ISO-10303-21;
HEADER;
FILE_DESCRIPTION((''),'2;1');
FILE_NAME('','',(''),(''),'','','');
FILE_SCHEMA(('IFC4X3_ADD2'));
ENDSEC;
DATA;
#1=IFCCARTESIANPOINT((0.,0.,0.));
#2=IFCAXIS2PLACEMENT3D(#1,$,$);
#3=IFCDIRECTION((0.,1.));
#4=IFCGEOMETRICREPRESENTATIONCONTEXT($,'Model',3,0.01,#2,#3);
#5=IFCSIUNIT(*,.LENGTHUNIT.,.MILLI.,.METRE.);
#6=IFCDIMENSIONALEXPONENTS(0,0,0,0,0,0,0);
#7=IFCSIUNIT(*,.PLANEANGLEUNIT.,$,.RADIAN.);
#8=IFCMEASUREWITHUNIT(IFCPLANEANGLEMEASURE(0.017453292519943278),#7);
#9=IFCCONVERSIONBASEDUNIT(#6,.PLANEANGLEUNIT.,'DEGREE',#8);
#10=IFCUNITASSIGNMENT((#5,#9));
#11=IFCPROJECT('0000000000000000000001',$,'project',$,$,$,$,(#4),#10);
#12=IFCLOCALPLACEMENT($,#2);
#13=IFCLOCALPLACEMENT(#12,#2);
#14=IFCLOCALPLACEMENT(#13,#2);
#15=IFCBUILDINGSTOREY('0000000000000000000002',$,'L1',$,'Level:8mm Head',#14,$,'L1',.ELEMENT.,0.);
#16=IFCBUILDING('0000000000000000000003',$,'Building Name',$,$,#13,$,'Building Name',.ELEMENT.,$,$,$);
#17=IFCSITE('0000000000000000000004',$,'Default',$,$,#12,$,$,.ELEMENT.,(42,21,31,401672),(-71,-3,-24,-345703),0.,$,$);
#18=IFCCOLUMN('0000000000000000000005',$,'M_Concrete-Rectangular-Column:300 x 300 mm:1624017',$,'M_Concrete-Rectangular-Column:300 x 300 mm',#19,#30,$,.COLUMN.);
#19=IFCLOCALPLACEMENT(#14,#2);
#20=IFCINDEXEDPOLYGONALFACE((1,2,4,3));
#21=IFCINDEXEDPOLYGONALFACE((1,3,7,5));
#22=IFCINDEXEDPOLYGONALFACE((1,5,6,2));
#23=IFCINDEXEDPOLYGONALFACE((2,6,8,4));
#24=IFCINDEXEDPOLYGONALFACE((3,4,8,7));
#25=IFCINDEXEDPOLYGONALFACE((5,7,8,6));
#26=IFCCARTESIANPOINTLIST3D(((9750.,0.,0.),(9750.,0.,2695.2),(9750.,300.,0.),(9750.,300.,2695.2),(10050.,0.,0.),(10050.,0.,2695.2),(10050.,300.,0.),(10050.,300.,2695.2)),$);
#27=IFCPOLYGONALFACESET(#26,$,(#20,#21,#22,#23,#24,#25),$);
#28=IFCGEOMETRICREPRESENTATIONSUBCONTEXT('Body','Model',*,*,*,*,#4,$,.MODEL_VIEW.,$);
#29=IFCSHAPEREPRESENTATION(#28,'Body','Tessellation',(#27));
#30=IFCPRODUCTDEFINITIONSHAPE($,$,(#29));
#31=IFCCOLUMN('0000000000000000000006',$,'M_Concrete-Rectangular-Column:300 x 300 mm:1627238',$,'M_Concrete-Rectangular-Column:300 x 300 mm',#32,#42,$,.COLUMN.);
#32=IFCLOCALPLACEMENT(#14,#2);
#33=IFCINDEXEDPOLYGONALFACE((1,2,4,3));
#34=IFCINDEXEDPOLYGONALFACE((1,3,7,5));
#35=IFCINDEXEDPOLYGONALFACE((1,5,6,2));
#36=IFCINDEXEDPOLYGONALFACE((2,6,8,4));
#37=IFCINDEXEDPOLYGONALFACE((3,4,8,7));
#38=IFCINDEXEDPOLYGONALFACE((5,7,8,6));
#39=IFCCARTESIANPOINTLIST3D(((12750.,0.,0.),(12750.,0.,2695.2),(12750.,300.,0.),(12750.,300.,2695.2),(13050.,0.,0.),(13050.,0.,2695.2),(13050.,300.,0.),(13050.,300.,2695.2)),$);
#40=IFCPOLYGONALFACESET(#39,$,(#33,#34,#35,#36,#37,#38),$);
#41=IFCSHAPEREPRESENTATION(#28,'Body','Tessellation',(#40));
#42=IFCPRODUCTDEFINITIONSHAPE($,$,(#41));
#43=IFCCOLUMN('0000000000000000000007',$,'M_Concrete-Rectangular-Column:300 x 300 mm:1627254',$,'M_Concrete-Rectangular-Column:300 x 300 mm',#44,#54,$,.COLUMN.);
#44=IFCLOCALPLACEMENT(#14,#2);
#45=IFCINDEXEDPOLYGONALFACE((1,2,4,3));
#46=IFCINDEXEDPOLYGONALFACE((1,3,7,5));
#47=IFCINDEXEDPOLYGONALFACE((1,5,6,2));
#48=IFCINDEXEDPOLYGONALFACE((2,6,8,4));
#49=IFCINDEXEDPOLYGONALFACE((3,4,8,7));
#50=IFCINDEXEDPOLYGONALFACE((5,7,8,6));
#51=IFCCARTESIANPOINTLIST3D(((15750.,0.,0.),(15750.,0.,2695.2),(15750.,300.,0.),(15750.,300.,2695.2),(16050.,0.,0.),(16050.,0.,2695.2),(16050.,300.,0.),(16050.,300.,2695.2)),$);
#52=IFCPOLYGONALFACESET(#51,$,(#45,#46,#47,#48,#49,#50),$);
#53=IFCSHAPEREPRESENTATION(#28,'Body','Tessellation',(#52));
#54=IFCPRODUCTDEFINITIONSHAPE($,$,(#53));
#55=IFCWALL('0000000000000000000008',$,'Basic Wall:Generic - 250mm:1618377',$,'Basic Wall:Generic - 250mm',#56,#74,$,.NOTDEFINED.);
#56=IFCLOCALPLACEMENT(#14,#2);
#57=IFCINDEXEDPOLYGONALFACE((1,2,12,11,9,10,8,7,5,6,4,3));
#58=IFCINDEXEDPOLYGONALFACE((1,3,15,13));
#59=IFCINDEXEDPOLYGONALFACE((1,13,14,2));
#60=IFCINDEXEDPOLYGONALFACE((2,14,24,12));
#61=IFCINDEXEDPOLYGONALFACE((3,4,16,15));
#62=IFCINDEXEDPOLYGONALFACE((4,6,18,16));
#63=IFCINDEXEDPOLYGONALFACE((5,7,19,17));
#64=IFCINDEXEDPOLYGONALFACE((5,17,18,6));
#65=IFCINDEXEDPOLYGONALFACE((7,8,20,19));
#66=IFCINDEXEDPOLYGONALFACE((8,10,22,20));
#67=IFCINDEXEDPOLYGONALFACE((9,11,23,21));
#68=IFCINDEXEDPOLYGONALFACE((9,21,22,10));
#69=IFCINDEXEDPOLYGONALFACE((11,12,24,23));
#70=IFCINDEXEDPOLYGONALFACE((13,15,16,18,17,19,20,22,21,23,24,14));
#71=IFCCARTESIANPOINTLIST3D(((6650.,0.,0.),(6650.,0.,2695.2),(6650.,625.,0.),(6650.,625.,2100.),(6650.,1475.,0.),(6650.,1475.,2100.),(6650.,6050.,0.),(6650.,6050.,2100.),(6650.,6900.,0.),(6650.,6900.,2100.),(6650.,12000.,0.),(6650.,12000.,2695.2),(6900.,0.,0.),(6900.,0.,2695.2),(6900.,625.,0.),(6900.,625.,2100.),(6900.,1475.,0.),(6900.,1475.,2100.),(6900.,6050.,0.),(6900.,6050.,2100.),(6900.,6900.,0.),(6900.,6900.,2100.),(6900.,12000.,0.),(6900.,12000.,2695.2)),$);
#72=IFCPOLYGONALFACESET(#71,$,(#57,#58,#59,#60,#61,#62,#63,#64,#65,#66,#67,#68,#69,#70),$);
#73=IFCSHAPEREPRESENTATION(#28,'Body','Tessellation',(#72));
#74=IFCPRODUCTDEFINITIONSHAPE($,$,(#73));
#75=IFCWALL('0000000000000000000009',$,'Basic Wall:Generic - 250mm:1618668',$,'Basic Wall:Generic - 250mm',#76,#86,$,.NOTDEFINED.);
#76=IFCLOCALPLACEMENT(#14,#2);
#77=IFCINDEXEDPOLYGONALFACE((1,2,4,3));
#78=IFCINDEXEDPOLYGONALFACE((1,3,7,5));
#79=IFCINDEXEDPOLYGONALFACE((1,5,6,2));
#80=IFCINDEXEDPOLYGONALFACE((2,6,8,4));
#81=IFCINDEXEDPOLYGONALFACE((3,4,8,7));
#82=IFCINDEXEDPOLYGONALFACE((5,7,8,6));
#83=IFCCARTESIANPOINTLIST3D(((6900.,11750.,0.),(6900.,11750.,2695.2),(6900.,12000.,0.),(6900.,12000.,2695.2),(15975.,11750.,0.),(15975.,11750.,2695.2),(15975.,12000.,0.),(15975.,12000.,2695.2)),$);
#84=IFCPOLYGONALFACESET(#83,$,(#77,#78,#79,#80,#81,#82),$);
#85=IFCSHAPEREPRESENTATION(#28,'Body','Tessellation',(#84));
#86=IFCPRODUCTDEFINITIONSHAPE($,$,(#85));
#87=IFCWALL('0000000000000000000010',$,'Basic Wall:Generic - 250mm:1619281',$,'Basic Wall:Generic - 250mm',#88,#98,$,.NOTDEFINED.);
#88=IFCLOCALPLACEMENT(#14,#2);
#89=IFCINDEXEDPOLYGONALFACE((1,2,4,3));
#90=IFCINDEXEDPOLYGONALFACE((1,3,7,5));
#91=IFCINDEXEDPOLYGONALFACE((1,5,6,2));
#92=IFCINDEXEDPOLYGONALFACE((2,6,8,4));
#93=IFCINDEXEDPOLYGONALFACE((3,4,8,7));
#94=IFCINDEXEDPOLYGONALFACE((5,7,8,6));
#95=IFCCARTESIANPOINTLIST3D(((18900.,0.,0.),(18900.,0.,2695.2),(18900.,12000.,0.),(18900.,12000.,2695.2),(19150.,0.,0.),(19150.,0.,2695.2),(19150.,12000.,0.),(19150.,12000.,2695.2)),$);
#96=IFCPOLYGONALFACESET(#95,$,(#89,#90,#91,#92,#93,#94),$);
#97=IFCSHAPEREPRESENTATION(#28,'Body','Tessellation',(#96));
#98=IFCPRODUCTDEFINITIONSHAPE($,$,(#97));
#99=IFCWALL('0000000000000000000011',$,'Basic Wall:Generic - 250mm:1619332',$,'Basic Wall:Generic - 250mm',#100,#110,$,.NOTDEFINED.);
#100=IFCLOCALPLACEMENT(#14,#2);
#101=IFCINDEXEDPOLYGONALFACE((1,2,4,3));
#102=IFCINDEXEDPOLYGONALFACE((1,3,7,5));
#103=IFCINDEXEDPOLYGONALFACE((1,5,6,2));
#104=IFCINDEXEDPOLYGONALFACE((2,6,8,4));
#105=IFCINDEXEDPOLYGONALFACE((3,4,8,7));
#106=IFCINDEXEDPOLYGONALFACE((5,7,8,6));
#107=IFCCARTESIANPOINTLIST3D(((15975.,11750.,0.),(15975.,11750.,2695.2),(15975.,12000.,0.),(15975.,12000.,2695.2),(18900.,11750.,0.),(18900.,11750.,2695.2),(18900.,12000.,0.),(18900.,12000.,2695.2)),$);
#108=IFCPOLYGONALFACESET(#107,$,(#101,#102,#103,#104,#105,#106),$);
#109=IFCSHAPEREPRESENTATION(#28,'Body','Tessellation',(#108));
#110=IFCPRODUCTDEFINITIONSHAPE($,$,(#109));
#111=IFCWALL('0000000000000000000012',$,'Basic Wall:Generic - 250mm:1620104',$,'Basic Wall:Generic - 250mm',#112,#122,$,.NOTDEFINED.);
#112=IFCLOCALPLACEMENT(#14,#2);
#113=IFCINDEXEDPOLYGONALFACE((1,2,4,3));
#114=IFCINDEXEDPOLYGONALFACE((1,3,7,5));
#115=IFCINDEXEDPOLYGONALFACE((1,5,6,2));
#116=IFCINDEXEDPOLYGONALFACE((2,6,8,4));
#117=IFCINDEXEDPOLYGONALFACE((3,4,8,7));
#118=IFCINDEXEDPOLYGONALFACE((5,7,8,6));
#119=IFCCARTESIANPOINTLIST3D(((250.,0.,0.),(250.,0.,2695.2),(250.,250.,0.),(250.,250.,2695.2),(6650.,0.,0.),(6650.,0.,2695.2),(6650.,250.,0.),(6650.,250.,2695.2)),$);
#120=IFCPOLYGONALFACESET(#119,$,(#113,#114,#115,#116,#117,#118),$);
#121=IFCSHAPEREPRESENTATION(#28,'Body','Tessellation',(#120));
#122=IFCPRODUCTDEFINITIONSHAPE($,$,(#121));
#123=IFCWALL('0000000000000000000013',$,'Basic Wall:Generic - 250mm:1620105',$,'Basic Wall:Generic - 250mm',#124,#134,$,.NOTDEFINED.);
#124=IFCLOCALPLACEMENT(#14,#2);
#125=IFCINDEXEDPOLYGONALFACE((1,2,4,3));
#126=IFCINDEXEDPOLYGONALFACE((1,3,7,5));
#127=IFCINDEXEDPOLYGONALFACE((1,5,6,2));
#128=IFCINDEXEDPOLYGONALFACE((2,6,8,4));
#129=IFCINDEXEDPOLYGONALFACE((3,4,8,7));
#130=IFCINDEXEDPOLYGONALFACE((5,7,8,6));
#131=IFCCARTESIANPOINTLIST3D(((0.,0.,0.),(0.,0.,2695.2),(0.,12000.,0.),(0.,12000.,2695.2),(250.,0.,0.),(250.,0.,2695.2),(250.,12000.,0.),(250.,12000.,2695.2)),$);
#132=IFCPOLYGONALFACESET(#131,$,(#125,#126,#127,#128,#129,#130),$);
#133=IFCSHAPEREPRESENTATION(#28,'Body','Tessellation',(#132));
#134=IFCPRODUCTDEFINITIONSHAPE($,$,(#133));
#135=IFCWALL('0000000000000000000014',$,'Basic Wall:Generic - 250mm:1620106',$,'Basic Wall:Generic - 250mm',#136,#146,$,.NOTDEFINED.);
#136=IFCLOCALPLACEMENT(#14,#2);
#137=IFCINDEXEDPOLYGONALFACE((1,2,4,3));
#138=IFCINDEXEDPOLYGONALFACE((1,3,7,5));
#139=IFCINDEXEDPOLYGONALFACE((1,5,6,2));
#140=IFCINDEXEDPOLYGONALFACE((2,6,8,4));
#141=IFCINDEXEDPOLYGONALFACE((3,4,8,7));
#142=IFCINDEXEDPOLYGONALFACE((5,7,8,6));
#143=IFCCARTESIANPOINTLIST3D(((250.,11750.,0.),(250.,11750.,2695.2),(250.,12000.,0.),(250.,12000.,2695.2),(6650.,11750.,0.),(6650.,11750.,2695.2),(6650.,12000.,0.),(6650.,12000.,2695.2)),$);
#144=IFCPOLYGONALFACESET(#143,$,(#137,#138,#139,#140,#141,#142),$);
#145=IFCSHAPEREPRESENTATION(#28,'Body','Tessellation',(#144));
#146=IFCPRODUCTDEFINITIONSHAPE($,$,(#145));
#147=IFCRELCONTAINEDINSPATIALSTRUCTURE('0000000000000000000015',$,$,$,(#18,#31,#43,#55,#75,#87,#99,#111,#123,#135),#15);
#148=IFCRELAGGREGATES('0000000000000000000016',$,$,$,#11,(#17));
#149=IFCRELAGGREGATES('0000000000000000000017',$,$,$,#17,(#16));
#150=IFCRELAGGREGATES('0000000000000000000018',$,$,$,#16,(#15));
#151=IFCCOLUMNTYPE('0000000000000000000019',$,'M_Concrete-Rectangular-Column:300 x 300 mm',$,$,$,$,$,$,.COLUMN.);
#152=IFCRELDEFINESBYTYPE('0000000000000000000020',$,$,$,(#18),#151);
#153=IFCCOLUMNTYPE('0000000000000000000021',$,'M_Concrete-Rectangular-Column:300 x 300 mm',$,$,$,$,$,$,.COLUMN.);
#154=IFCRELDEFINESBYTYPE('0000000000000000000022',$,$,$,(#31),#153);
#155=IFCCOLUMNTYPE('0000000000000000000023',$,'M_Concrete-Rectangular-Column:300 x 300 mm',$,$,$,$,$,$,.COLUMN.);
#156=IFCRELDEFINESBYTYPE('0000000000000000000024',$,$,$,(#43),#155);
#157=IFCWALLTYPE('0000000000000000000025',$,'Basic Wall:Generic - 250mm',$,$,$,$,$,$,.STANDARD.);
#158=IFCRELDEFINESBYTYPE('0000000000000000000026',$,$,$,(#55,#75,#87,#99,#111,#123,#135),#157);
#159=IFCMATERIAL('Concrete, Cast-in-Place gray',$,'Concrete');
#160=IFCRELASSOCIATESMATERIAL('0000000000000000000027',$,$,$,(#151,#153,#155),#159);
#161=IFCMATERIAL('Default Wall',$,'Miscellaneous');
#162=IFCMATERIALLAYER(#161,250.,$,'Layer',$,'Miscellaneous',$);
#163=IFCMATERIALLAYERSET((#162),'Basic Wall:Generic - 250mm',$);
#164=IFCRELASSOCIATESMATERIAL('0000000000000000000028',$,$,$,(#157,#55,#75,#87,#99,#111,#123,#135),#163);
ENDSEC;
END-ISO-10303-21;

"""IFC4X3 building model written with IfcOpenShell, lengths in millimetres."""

from ifc_helpers import new_model, entity, si_unit, converted_unit, direction, frame, frame_2d, origin, place, context, subcontext, project, spatial, polyline, rectangle, extrude, clip, bounded_halfspace, source, transform, mapped, material, layer, layer_set, material_profile, profile_set, type_object, type_shapes, element, save


model = new_model("IFC4X3")

# Units and contexts
model_context = context("Model", 3, precision=0.01, world=origin(), true_north=direction((0.0, 1.0)))
body_context = subcontext(model_context, "Body", "Model", "MODEL_VIEW")
ifc_project = project(units=[si_unit("LENGTHUNIT", "METRE", prefix="MILLI"), converted_unit("PLANEANGLEUNIT", "DEGREE", entity("IfcPlaneAngleMeasure", 0.017453292519943278), si_unit("PLANEANGLEUNIT", "RADIAN"), dimensions=[0, 0, 0, 0, 0, 0, 0])], contexts=[model_context])

# Site, building, storey
site_placement = place(None, origin())
site = spatial("IfcSite", under=ifc_project, at=site_placement, Name="Default", CompositionType="ELEMENT", RefLatitude=(42, 21, 31, 401672), RefLongitude=(-71, -3, -24, -345703), RefElevation=0.0)
building_placement = place(site_placement, origin())
building = spatial("IfcBuilding", under=site, at=building_placement, Name="Building Name", LongName="Building Name", CompositionType="ELEMENT")
storey_placement = place(building_placement, origin())
storey = spatial("IfcBuildingStorey", under=building, at=storey_placement, Name="L1", ObjectType="Level:8mm Head", LongName="L1", CompositionType="ELEMENT", Elevation=0.0)

# Columns
ifc_material_1 = material(Name="Concrete, Cast-in-Place gray", Category="Concrete")
ifc_material_profile = material_profile(ifc_material_1, rectangle(XDim=300.0, YDim=300.0, at=frame_2d((0.0, 0.0), x_axis=(1.0, 0.0))), Name="300 x 300 mm")
ifc_profile_set = profile_set([ifc_material_profile], Name="300 x 300 mm")
column_type_1 = type_object("IfcColumnType", Name="M_Concrete-Rectangular-Column:300 x 300 mm", PredefinedType="COLUMN", material=ifc_profile_set)
shared_shape_1 = source(origin(), body_context, "Body", "SweptSolid", [
    extrude(rectangle(XDim=300.0, YDim=300.0, at=frame_2d((0.0, 0.0), x_axis=(1.0, 0.0))), frame((9900.0, 150.0, 0.0), z_axis=(0.0, 0.0, 1.0), x_axis=(-1.0, 0.0, 0.0)), (0.0, 0.0, 1.0), 2695.2),
])
type_shapes(column_type_1, [shared_shape_1])
column_1_placement = place(storey_placement, origin())
element("IfcColumn", 1, at=column_1_placement, inside=storey, type_object=column_type_1, Name="M_Concrete-Rectangular-Column:300 x 300 mm:1624017", ObjectType="M_Concrete-Rectangular-Column:300 x 300 mm", PredefinedType="COLUMN", context=body_context, shape_type="MappedRepresentation", body=[
    mapped(shared_shape_1, transform((0.0, 0.0, 0.0), scale=1.0)),
])
column_type_2 = type_object("IfcColumnType", Name="M_Concrete-Rectangular-Column:300 x 300 mm", PredefinedType="COLUMN", material=ifc_profile_set)
shared_shape_2 = source(origin(), body_context, "Body", "SweptSolid", [
    extrude(rectangle(XDim=300.0, YDim=300.0, at=frame_2d((0.0, 0.0), x_axis=(1.0, 0.0))), frame((12900.0, 150.0, 0.0), z_axis=(0.0, 0.0, 1.0), x_axis=(-1.0, 0.0, 0.0)), (0.0, 0.0, 1.0), 2695.2),
])
type_shapes(column_type_2, [shared_shape_2])
column_2_placement = place(storey_placement, origin())
element("IfcColumn", 2, at=column_2_placement, inside=storey, type_object=column_type_2, Name="M_Concrete-Rectangular-Column:300 x 300 mm:1627238", ObjectType="M_Concrete-Rectangular-Column:300 x 300 mm", PredefinedType="COLUMN", context=body_context, shape_type="MappedRepresentation", body=[
    mapped(shared_shape_2, transform((0.0, 0.0, 0.0), scale=1.0)),
])
column_type_3 = type_object("IfcColumnType", Name="M_Concrete-Rectangular-Column:300 x 300 mm", PredefinedType="COLUMN", material=ifc_profile_set)
shared_shape_3 = source(origin(), body_context, "Body", "SweptSolid", [
    extrude(rectangle(XDim=300.0, YDim=300.0, at=frame_2d((0.0, 0.0), x_axis=(1.0, 0.0))), frame((15900.0, 150.0, 0.0), z_axis=(0.0, 0.0, 1.0), x_axis=(-1.0, 0.0, 0.0)), (0.0, 0.0, 1.0), 2695.2),
])
type_shapes(column_type_3, [shared_shape_3])
column_3_placement = place(storey_placement, origin())
element("IfcColumn", 3, at=column_3_placement, inside=storey, type_object=column_type_3, Name="M_Concrete-Rectangular-Column:300 x 300 mm:1627254", ObjectType="M_Concrete-Rectangular-Column:300 x 300 mm", PredefinedType="COLUMN", context=body_context, shape_type="MappedRepresentation", body=[
    mapped(shared_shape_3, transform((0.0, 0.0, 0.0), scale=1.0)),
])

# Wall, openings
ifc_material_2 = material(Name="Default Wall", Category="Miscellaneous")
ifc_layer = layer(ifc_material_2, 250.0, Name="Layer", Category="Miscellaneous")
ifc_layer_set = layer_set([ifc_layer], Name="Basic Wall:Generic - 250mm")
wall_type = type_object("IfcWallType", Name="Basic Wall:Generic - 250mm", PredefinedType="STANDARD", material=ifc_layer_set)
wall_1_placement = place(storey_placement, frame((6775.0, 12000.0, 0.0), z_axis=(0.0, 0.0, 1.0), x_axis=(0.0, -1.0, 0.0)))
wall_1 = element("IfcWall", 4, at=wall_1_placement, inside=storey, type_object=wall_type, material=ifc_layer_set, Name="Basic Wall:Generic - 250mm:1618377", ObjectType="Basic Wall:Generic - 250mm", PredefinedType="NOTDEFINED", context=body_context, shape_type="Clipping", body=[
    clip(extrude(rectangle(XDim=12000.0, YDim=250.0, at=frame_2d((6000.0, 0.0), x_axis=(1.0, 0.0))), origin(), (0.0, 0.0, 1.0), 2695.2), bounded_halfspace(frame((0.0, -125.0, 2695.2), z_axis=(0.0, 0.0, -1.0), x_axis=(0.0, -1.0, 0.0)), True, frame((0.0, -125.0, 2695.2)), polyline([(0.0, 0.0), (250.0, 0.0), (11750.0, 0.0), (12000.0, 0.0), (12000.0, 250.0), (250.0, 250.0), (0.0, 250.0), (0.0, 0.0)]))),
])
opening_1_placement = place(wall_1_placement, frame((10525.0, -125.0, 0.0)))
element("IfcOpeningElement", 5, at=opening_1_placement, cuts=wall_1, PredefinedType="OPENING", context=body_context, shape_type="SweptSolid", body=[
    extrude(rectangle(XDim=2100.0, YDim=850.0, at=frame_2d((1050.0, 425.0), x_axis=(1.0, 0.0))), frame((0.0, 0.0, 0.0), z_axis=(0.0, 1.0, 0.0), x_axis=(0.0, 0.0, 1.0)), (0.0, 0.0, 1.0), 250.0),
])
opening_2_placement = place(wall_1_placement, frame((5100.0, -125.0, 0.0)))
element("IfcOpeningElement", 6, at=opening_2_placement, cuts=wall_1, PredefinedType="OPENING", context=body_context, shape_type="SweptSolid", body=[
    extrude(rectangle(XDim=2100.0, YDim=850.0, at=frame_2d((1050.0, 425.0), x_axis=(1.0, 0.0))), frame((0.0, 0.0, 0.0), z_axis=(0.0, 1.0, 0.0), x_axis=(0.0, 0.0, 1.0)), (0.0, 0.0, 1.0), 250.0),
])

# Walls
wall_2_placement = place(storey_placement, frame((15975.0, 11875.0, 0.0), z_axis=(0.0, 0.0, 1.0), x_axis=(-1.0, 0.0, 0.0)))
element("IfcWall", 7, at=wall_2_placement, inside=storey, type_object=wall_type, material=ifc_layer_set, Name="Basic Wall:Generic - 250mm:1618668", ObjectType="Basic Wall:Generic - 250mm", PredefinedType="NOTDEFINED", context=body_context, shape_type="Clipping", body=[
    clip(extrude(rectangle(XDim=9075.0, YDim=250.0, at=frame_2d((4537.5, 0.0), x_axis=(-1.0, 0.0))), origin(), (0.0, 0.0, 1.0), 2695.2), bounded_halfspace(frame((0.0, -125.0, 2695.2), z_axis=(0.0, 0.0, -1.0), x_axis=(1.0, 0.0, 0.0)), True, frame((0.0, -125.0, 2695.2)), polyline([(0.0, 0.0), (9075.0, 0.0), (9075.0, 250.0), (0.0, 250.0), (0.0, 0.0)]))),
])
wall_3_placement = place(storey_placement, frame((19025.0, 0.0, 0.0), z_axis=(0.0, 0.0, 1.0), x_axis=(0.0, 1.0, 0.0)))
element("IfcWall", 8, at=wall_3_placement, inside=storey, type_object=wall_type, material=ifc_layer_set, Name="Basic Wall:Generic - 250mm:1619281", ObjectType="Basic Wall:Generic - 250mm", PredefinedType="NOTDEFINED", context=body_context, shape_type="Clipping", body=[
    clip(extrude(rectangle(XDim=12000.0, YDim=250.0, at=frame_2d((6000.0, 0.0), x_axis=(-1.0, 0.0))), origin(), (0.0, 0.0, 1.0), 2695.2), bounded_halfspace(frame((0.0, -125.0, 2695.2), z_axis=(0.0, 0.0, -1.0), x_axis=(0.0, 1.0, 0.0)), True, frame((0.0, -125.0, 2695.2)), polyline([(0.0, 0.0), (12000.0, 0.0), (12000.0, 250.0), (11750.0, 250.0), (0.0, 250.0), (0.0, 0.0)]))),
])
wall_4_placement = place(storey_placement, frame((18900.0, 11875.0, 0.0), z_axis=(0.0, 0.0, 1.0), x_axis=(-1.0, 0.0, 0.0)))
element("IfcWall", 9, at=wall_4_placement, inside=storey, type_object=wall_type, material=ifc_layer_set, Name="Basic Wall:Generic - 250mm:1619332", ObjectType="Basic Wall:Generic - 250mm", PredefinedType="NOTDEFINED", context=body_context, shape_type="Clipping", body=[
    clip(extrude(rectangle(XDim=2925.0, YDim=250.0, at=frame_2d((1462.5, 0.0), x_axis=(-1.0, 0.0))), origin(), (0.0, 0.0, 1.0), 2695.2), bounded_halfspace(frame((0.0, -125.0, 2695.2), z_axis=(0.0, 0.0, -1.0), x_axis=(1.0, 0.0, 0.0)), True, frame((0.0, -125.0, 2695.2)), polyline([(0.0, 0.0), (2925.0, 0.0), (2925.0, 250.0), (0.0, 250.0), (0.0, 0.0)]))),
])
wall_5_placement = place(storey_placement, frame((6650.0, 125.0, 0.0), z_axis=(0.0, 0.0, 1.0), x_axis=(-1.0, 0.0, 0.0)))
element("IfcWall", 10, at=wall_5_placement, inside=storey, type_object=wall_type, material=ifc_layer_set, Name="Basic Wall:Generic - 250mm:1620104", ObjectType="Basic Wall:Generic - 250mm", PredefinedType="NOTDEFINED", context=body_context, shape_type="Clipping", body=[
    clip(extrude(rectangle(XDim=6400.0, YDim=250.0, at=frame_2d((3200.0, 0.0), x_axis=(-1.0, 0.0))), origin(), (0.0, 0.0, 1.0), 2695.2), bounded_halfspace(frame((0.0, -125.0, 2695.2), z_axis=(0.0, 0.0, -1.0), x_axis=(1.0, 0.0, 0.0)), True, frame((0.0, -125.0, 2695.2)), polyline([(0.0, 0.0), (6400.0, 0.0), (6400.0, 250.0), (0.0, 250.0), (0.0, 0.0)]))),
])
wall_6_placement = place(storey_placement, frame((125.0, 0.0, 0.0), z_axis=(0.0, 0.0, 1.0), x_axis=(0.0, 1.0, 0.0)))
element("IfcWall", 11, at=wall_6_placement, inside=storey, type_object=wall_type, material=ifc_layer_set, Name="Basic Wall:Generic - 250mm:1620105", ObjectType="Basic Wall:Generic - 250mm", PredefinedType="NOTDEFINED", context=body_context, shape_type="Clipping", body=[
    clip(extrude(rectangle(XDim=12000.0, YDim=250.0, at=frame_2d((6000.0, 0.0), x_axis=(-1.0, 0.0))), origin(), (0.0, 0.0, 1.0), 2695.2), bounded_halfspace(frame((0.0, -125.0, 2695.2), z_axis=(0.0, 0.0, -1.0), x_axis=(0.0, 1.0, 0.0)), True, frame((0.0, -125.0, 2695.2)), polyline([(0.0, 0.0), (250.0, 0.0), (11750.0, 0.0), (12000.0, 0.0), (12000.0, 250.0), (0.0, 250.0), (0.0, 0.0)]))),
])
wall_7_placement = place(storey_placement, frame((250.0, 11875.0, 0.0)))
element("IfcWall", 12, at=wall_7_placement, inside=storey, type_object=wall_type, material=ifc_layer_set, Name="Basic Wall:Generic - 250mm:1620106", ObjectType="Basic Wall:Generic - 250mm", PredefinedType="NOTDEFINED", context=body_context, shape_type="Clipping", body=[
    clip(extrude(rectangle(XDim=6400.0, YDim=250.0, at=frame_2d((3200.0, 0.0), x_axis=(-1.0, 0.0))), origin(), (0.0, 0.0, 1.0), 2695.2), bounded_halfspace(frame((0.0, -125.0, 2695.2), z_axis=(0.0, 0.0, -1.0), x_axis=(-1.0, 0.0, 0.0)), True, frame((0.0, -125.0, 2695.2)), polyline([(0.0, 0.0), (6400.0, 0.0), (6400.0, 250.0), (0.0, 250.0), (0.0, 0.0)]))),
])

save(model, "model.ifc")
